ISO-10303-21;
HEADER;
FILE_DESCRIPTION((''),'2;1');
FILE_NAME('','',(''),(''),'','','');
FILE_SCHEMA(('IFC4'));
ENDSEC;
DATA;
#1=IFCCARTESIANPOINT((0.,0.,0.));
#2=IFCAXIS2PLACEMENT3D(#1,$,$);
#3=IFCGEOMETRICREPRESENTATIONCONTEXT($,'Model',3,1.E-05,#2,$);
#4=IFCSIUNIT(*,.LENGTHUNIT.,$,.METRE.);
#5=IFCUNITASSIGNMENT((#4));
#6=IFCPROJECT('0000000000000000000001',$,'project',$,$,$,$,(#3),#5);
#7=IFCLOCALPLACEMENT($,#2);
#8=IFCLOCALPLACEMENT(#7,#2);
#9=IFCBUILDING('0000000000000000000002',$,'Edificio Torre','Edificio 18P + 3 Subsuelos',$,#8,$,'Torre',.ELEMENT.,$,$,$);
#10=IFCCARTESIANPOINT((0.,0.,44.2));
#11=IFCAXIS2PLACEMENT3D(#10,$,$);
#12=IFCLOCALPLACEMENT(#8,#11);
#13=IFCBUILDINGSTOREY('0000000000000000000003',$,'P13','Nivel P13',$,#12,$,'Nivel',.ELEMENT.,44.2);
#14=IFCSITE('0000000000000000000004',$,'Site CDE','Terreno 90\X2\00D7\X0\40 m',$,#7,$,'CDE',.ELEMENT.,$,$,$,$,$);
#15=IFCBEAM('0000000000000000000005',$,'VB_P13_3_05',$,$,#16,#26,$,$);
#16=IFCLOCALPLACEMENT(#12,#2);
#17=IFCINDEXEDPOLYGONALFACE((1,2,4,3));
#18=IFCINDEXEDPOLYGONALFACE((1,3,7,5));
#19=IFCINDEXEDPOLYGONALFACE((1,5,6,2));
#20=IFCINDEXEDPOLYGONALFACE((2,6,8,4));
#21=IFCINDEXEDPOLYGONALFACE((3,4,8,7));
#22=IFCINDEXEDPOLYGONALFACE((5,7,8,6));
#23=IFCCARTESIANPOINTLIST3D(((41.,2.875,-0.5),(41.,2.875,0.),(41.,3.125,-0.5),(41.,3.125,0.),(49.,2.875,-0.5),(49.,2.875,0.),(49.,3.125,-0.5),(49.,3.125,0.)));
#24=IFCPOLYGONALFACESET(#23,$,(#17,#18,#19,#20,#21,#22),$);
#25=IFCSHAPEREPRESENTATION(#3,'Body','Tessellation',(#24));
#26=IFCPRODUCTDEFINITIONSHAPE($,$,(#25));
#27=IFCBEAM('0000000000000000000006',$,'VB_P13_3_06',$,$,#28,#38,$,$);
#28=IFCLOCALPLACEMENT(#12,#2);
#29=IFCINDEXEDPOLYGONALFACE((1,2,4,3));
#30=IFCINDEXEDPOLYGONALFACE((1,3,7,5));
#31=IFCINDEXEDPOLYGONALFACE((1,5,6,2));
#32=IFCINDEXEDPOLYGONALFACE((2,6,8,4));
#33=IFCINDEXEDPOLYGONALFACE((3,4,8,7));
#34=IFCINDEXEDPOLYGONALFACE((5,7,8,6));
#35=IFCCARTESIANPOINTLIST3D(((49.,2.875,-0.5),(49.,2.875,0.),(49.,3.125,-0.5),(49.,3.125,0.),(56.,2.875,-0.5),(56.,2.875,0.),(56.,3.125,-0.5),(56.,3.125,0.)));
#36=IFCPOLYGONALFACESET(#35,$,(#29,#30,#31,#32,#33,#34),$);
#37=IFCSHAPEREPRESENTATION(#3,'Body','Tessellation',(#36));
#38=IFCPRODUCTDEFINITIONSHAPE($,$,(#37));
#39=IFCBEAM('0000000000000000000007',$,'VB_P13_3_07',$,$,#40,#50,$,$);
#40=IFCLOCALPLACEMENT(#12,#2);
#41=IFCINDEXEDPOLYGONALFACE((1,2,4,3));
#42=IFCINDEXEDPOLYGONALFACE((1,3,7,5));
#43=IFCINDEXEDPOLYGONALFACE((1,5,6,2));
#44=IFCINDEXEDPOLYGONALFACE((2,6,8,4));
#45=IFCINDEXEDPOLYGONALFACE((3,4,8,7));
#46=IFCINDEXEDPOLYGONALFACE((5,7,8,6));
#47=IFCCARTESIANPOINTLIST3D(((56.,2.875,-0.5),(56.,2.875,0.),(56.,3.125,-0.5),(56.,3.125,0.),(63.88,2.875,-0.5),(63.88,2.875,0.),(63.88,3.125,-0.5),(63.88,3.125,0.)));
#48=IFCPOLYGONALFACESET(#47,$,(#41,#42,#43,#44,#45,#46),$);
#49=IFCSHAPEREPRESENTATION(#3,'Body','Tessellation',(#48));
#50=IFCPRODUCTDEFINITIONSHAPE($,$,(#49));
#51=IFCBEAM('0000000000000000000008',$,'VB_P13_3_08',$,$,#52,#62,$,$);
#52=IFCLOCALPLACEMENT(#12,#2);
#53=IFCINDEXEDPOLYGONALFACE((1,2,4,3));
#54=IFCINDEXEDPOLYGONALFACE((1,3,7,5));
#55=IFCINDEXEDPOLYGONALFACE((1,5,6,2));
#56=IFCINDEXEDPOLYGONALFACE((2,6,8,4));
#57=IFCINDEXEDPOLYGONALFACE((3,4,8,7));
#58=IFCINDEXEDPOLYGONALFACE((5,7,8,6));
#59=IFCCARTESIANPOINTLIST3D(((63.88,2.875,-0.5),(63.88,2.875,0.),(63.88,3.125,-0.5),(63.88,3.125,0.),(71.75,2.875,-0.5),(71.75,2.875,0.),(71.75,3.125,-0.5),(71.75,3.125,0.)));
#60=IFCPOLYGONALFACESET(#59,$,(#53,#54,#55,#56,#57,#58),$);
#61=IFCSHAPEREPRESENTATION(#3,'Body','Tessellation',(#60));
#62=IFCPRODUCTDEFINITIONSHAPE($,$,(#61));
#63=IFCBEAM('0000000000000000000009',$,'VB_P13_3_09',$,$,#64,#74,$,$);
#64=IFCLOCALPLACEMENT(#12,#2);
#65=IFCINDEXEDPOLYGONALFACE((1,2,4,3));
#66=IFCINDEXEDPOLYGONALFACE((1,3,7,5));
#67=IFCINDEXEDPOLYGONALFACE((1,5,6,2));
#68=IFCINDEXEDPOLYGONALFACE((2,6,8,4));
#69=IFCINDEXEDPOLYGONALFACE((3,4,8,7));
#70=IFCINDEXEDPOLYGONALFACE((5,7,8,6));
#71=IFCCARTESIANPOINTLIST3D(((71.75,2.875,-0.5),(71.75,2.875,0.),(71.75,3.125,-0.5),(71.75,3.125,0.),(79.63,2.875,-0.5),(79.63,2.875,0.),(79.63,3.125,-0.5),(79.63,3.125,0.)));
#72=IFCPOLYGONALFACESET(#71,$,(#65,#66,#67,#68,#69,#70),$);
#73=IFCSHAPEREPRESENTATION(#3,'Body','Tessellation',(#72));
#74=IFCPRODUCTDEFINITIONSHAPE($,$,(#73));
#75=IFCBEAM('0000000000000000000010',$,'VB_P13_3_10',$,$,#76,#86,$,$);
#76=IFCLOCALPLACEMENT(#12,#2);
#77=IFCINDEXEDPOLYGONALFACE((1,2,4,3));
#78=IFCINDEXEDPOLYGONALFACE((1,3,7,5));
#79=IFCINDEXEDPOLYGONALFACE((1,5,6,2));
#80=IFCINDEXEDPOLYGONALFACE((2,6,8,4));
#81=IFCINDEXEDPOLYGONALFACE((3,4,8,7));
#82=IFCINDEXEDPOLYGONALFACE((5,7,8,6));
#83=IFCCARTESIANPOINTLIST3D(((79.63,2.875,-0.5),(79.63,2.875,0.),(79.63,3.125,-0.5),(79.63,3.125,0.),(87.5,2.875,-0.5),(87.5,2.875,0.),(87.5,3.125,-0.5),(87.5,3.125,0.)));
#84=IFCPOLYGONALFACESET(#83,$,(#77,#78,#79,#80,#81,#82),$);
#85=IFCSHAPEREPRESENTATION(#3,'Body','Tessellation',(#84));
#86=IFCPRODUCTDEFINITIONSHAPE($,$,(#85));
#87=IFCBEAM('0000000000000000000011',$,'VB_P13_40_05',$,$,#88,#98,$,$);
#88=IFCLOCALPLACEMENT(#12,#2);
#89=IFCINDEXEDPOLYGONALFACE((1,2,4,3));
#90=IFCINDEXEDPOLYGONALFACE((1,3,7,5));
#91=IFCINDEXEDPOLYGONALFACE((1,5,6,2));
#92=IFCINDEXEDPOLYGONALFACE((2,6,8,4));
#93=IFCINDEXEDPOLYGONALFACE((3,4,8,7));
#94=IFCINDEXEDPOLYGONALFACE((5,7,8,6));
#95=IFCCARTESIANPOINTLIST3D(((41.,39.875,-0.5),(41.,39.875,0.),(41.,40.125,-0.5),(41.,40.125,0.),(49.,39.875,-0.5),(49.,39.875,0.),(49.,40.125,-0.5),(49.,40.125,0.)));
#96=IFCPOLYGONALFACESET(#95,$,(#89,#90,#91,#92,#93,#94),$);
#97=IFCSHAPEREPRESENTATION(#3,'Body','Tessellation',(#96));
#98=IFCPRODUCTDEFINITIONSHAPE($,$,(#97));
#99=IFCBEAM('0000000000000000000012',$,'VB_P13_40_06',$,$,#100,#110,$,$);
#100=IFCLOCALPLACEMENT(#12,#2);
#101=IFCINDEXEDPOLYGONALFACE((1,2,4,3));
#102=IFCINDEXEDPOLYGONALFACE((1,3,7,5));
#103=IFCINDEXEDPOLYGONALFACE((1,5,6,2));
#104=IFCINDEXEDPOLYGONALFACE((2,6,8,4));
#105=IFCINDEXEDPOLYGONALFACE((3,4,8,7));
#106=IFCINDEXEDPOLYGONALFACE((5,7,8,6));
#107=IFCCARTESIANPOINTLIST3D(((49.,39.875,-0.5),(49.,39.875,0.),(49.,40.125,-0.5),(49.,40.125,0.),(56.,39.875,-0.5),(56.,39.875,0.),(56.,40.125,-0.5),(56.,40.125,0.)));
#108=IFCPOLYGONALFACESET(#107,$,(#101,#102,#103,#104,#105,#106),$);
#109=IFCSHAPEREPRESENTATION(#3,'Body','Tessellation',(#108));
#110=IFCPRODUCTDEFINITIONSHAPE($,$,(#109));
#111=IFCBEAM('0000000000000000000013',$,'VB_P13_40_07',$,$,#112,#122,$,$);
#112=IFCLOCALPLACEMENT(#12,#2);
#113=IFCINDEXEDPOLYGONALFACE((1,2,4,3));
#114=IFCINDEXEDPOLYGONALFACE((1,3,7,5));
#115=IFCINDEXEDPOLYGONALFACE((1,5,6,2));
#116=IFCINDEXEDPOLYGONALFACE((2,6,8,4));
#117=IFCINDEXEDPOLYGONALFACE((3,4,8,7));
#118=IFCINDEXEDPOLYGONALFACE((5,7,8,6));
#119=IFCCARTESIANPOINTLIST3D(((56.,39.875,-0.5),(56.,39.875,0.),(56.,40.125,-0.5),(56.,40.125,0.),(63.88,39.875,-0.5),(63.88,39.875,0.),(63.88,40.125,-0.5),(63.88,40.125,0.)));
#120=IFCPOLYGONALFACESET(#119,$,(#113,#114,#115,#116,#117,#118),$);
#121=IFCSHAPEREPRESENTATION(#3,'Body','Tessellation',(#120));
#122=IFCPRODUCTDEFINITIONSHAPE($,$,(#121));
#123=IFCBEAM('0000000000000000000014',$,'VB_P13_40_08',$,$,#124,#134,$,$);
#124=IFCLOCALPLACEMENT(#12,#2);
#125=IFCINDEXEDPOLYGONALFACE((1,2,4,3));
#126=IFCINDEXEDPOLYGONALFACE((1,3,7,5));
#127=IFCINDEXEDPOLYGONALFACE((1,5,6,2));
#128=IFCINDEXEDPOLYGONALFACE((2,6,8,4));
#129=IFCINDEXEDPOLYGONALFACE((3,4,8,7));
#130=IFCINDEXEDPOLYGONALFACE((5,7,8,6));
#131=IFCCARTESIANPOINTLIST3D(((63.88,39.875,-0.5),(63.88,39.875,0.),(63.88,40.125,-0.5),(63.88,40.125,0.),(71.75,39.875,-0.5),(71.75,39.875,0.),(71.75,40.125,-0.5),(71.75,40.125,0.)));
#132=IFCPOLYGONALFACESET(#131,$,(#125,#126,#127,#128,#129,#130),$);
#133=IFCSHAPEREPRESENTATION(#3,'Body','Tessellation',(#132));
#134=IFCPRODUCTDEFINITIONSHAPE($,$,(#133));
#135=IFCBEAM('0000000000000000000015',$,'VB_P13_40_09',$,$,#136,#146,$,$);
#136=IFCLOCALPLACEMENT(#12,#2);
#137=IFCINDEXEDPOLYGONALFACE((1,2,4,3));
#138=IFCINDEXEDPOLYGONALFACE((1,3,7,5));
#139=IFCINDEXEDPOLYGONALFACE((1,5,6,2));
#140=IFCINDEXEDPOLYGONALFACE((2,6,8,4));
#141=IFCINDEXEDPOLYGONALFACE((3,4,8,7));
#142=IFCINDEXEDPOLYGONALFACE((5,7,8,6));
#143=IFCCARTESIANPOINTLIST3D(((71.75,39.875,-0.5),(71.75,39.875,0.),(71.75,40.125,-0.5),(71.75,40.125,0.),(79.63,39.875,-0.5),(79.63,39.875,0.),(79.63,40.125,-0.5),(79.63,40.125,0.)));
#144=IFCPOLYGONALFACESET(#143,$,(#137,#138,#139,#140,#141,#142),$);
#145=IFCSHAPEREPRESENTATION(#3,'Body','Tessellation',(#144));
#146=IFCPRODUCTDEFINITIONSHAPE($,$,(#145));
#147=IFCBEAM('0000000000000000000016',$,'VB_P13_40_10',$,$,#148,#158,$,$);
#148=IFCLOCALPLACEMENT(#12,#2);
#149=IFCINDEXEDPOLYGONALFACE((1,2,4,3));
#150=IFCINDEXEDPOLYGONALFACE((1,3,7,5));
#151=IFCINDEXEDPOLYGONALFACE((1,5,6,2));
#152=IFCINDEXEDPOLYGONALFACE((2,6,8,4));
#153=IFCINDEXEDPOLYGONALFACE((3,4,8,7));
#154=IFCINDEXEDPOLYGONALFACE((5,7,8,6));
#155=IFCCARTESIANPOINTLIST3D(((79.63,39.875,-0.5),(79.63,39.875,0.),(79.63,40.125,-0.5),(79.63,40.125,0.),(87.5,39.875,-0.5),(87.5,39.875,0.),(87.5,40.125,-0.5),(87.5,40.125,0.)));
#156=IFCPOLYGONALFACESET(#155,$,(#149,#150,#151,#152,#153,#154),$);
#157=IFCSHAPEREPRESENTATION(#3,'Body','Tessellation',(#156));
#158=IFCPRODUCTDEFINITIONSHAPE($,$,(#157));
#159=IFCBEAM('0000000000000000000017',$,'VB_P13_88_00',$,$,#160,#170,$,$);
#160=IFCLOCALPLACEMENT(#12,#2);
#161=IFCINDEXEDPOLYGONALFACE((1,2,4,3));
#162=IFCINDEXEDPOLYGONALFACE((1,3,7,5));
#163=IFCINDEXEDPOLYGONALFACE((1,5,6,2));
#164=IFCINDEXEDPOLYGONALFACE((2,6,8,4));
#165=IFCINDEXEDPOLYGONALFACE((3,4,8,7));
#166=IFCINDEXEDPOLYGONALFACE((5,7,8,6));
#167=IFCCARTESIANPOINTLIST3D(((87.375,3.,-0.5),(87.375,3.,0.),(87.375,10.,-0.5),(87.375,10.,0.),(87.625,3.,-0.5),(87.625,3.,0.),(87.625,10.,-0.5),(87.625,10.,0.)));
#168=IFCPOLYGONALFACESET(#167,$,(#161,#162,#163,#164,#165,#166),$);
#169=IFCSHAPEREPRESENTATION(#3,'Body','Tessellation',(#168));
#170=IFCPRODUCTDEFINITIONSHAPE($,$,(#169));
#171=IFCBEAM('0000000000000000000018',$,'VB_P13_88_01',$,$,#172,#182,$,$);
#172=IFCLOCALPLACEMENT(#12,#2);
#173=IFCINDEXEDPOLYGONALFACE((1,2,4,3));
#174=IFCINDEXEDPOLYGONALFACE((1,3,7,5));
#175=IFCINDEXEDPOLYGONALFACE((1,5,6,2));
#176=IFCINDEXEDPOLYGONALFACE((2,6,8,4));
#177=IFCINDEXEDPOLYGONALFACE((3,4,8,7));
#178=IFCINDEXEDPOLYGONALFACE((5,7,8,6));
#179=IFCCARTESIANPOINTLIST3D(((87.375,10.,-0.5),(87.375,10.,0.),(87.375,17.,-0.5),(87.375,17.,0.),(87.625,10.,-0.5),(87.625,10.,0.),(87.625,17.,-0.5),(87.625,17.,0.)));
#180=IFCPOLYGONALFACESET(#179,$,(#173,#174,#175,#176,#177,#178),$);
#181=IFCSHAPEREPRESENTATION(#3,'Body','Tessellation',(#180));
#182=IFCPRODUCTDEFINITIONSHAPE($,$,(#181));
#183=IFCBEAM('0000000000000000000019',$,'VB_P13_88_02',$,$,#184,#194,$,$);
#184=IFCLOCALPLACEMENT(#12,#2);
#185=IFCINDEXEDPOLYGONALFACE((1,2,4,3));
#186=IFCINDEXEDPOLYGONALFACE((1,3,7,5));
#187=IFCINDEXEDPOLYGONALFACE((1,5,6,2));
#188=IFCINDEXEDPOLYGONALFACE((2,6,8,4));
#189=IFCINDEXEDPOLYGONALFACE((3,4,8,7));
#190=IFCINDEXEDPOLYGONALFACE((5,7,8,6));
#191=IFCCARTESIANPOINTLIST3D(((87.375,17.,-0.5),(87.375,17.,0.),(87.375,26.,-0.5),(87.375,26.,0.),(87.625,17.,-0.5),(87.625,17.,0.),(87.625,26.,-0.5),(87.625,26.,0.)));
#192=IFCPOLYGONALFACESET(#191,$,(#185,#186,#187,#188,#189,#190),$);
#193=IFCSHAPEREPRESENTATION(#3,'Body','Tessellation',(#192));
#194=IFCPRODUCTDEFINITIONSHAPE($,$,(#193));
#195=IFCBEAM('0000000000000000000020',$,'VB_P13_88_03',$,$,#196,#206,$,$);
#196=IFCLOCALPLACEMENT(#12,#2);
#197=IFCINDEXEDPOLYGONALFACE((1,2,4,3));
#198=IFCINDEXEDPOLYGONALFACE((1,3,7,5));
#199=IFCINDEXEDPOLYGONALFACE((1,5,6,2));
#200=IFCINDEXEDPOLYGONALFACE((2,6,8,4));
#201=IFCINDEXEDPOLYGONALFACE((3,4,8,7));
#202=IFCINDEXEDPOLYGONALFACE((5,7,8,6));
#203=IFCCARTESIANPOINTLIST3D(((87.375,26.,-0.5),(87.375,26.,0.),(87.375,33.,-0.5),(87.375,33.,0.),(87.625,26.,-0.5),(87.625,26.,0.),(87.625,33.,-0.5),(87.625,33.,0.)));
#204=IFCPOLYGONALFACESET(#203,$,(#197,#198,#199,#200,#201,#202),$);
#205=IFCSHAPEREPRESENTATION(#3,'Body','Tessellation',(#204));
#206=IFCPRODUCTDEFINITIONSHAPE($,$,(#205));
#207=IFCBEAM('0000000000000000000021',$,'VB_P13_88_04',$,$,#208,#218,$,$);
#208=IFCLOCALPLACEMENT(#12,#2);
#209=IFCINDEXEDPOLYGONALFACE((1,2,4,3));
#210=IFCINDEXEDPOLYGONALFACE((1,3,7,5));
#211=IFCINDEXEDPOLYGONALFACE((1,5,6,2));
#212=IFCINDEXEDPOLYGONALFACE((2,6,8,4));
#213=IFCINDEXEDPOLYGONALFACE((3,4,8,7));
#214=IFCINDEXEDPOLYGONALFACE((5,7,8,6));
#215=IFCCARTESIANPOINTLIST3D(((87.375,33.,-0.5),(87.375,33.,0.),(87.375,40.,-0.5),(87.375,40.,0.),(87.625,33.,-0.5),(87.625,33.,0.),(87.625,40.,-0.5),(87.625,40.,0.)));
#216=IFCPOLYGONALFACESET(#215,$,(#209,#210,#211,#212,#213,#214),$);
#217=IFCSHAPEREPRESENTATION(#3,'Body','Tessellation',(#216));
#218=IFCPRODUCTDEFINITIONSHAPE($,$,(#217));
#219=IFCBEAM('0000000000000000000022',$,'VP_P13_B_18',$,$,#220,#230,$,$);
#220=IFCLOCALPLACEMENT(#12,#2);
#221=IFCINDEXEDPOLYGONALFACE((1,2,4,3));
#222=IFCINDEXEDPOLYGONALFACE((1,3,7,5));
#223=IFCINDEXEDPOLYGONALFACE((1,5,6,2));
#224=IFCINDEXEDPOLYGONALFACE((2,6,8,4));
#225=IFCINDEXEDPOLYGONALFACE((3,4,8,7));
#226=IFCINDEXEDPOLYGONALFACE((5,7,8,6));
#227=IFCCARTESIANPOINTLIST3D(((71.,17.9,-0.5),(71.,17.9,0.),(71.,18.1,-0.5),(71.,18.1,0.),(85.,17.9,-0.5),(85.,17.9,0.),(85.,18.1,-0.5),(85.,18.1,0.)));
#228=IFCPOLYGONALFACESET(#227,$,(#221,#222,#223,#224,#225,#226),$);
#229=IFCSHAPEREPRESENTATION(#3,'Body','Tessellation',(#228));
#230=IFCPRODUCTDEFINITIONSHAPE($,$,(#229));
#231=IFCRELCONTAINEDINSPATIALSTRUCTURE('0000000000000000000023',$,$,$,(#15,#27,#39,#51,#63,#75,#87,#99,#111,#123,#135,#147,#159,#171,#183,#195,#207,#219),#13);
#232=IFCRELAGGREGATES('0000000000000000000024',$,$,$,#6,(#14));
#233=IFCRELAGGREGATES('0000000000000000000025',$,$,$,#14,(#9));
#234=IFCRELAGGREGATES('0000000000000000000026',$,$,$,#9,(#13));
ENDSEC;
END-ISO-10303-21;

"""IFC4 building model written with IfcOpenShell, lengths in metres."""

from ifc_helpers import new_model, si_unit, frame, origin, origin_2d, place, context, project, spatial, rectangle, extrude, element, save


model = new_model("IFC4")

# Units and contexts
model_context = context("Model", 3, precision=1e-05, world=origin())
ifc_project = project(units=[si_unit("LENGTHUNIT", "METRE")], contexts=[model_context])

# Site, building, storey
site_placement = place(None, origin())
site = spatial("IfcSite", under=ifc_project, at=site_placement, Name="Site CDE", Description="Terreno 90×40 m", LongName="CDE", CompositionType="ELEMENT")
building_placement = place(site_placement, origin())
building = spatial("IfcBuilding", under=site, at=building_placement, Name="Edificio Torre", Description="Edificio 18P + 3 Subsuelos", LongName="Torre", CompositionType="ELEMENT")
storey_placement = place(building_placement, frame((0.0, 0.0, 44.2)))
storey = spatial("IfcBuildingStorey", under=building, at=storey_placement, Name="P13", Description="Nivel P13", LongName="Nivel", CompositionType="ELEMENT", Elevation=44.2)

# Beams
beam_1_placement = place(storey_placement, frame((45.0, 3.0, -0.5)))
element("IfcBeam", 1, at=beam_1_placement, inside=storey, Name="VB_P13_3_05", context=model_context, shape_type="SweptSolid", body=[
    extrude(rectangle(XDim=8.0, YDim=0.25, at=origin_2d()), origin(), (0.0, 0.0, 1.0), 0.5),
])
beam_2_placement = place(storey_placement, frame((52.5, 3.0, -0.5)))
element("IfcBeam", 2, at=beam_2_placement, inside=storey, Name="VB_P13_3_06", context=model_context, shape_type="SweptSolid", body=[
    extrude(rectangle(XDim=7.0, YDim=0.25, at=origin_2d()), origin(), (0.0, 0.0, 1.0), 0.5),
])
beam_3_placement = place(storey_placement, frame((59.94, 3.0, -0.5)))
element("IfcBeam", 3, at=beam_3_placement, inside=storey, Name="VB_P13_3_07", context=model_context, shape_type="SweptSolid", body=[
    extrude(rectangle(XDim=7.88, YDim=0.25, at=origin_2d()), origin(), (0.0, 0.0, 1.0), 0.5),
])
beam_4_placement = place(storey_placement, frame((67.815, 3.0, -0.5)))
element("IfcBeam", 4, at=beam_4_placement, inside=storey, Name="VB_P13_3_08", context=model_context, shape_type="SweptSolid", body=[
    extrude(rectangle(XDim=7.87, YDim=0.25, at=origin_2d()), origin(), (0.0, 0.0, 1.0), 0.5),
])
beam_5_placement = place(storey_placement, frame((75.69, 3.0, -0.5)))
element("IfcBeam", 5, at=beam_5_placement, inside=storey, Name="VB_P13_3_09", context=model_context, shape_type="SweptSolid", body=[
    extrude(rectangle(XDim=7.88, YDim=0.25, at=origin_2d()), origin(), (0.0, 0.0, 1.0), 0.5),
])
beam_6_placement = place(storey_placement, frame((83.565, 3.0, -0.5)))
element("IfcBeam", 6, at=beam_6_placement, inside=storey, Name="VB_P13_3_10", context=model_context, shape_type="SweptSolid", body=[
    extrude(rectangle(XDim=7.87, YDim=0.25, at=origin_2d()), origin(), (0.0, 0.0, 1.0), 0.5),
])
beam_7_placement = place(storey_placement, frame((45.0, 40.0, -0.5)))
element("IfcBeam", 7, at=beam_7_placement, inside=storey, Name="VB_P13_40_05", context=model_context, shape_type="SweptSolid", body=[
    extrude(rectangle(XDim=8.0, YDim=0.25, at=origin_2d()), origin(), (0.0, 0.0, 1.0), 0.5),
])
beam_8_placement = place(storey_placement, frame((52.5, 40.0, -0.5)))
element("IfcBeam", 8, at=beam_8_placement, inside=storey, Name="VB_P13_40_06", context=model_context, shape_type="SweptSolid", body=[
    extrude(rectangle(XDim=7.0, YDim=0.25, at=origin_2d()), origin(), (0.0, 0.0, 1.0), 0.5),
])
beam_9_placement = place(storey_placement, frame((59.94, 40.0, -0.5)))
element("IfcBeam", 9, at=beam_9_placement, inside=storey, Name="VB_P13_40_07", context=model_context, shape_type="SweptSolid", body=[
    extrude(rectangle(XDim=7.88, YDim=0.25, at=origin_2d()), origin(), (0.0, 0.0, 1.0), 0.5),
])
beam_10_placement = place(storey_placement, frame((67.815, 40.0, -0.5)))
element("IfcBeam", 10, at=beam_10_placement, inside=storey, Name="VB_P13_40_08", context=model_context, shape_type="SweptSolid", body=[
    extrude(rectangle(XDim=7.87, YDim=0.25, at=origin_2d()), origin(), (0.0, 0.0, 1.0), 0.5),
])
beam_11_placement = place(storey_placement, frame((75.69, 40.0, -0.5)))
element("IfcBeam", 11, at=beam_11_placement, inside=storey, Name="VB_P13_40_09", context=model_context, shape_type="SweptSolid", body=[
    extrude(rectangle(XDim=7.88, YDim=0.25, at=origin_2d()), origin(), (0.0, 0.0, 1.0), 0.5),
])
beam_12_placement = place(storey_placement, frame((83.565, 40.0, -0.5)))
element("IfcBeam", 12, at=beam_12_placement, inside=storey, Name="VB_P13_40_10", context=model_context, shape_type="SweptSolid", body=[
    extrude(rectangle(XDim=7.87, YDim=0.25, at=origin_2d()), origin(), (0.0, 0.0, 1.0), 0.5),
])
for number, where, name in (
    (13, (87.5, 6.5, -0.5), "VB_P13_88_00"),
    (14, (87.5, 13.5, -0.5), "VB_P13_88_01"),
):
    element("IfcBeam", number, at=place(storey_placement, frame(where)), inside=storey, Name=name, context=model_context, shape_type="SweptSolid", body=[
        extrude(rectangle(XDim=0.25, YDim=7.0, at=origin_2d()), origin(), (0.0, 0.0, 1.0), 0.5),
    ])
beam_13_placement = place(storey_placement, frame((87.5, 21.5, -0.5)))
element("IfcBeam", 15, at=beam_13_placement, inside=storey, Name="VB_P13_88_02", context=model_context, shape_type="SweptSolid", body=[
    extrude(rectangle(XDim=0.25, YDim=9.0, at=origin_2d()), origin(), (0.0, 0.0, 1.0), 0.5),
])
for number, where, name in (
    (16, (87.5, 29.5, -0.5), "VB_P13_88_03"),
    (17, (87.5, 36.5, -0.5), "VB_P13_88_04"),
):
    element("IfcBeam", number, at=place(storey_placement, frame(where)), inside=storey, Name=name, context=model_context, shape_type="SweptSolid", body=[
        extrude(rectangle(XDim=0.25, YDim=7.0, at=origin_2d()), origin(), (0.0, 0.0, 1.0), 0.5),
    ])
for number, where, name in (
    (18, (78.0, 18.0, -0.5), "VP_P13_B_18"),
):
    element("IfcBeam", number, at=place(storey_placement, frame(where)), inside=storey, Name=name, context=model_context, shape_type="SweptSolid", body=[
        extrude(rectangle(XDim=14.0, YDim=0.2, at=origin_2d()), origin(), (0.0, 0.0, 1.0), 0.5),
    ])

save(model, "model.ifc")
